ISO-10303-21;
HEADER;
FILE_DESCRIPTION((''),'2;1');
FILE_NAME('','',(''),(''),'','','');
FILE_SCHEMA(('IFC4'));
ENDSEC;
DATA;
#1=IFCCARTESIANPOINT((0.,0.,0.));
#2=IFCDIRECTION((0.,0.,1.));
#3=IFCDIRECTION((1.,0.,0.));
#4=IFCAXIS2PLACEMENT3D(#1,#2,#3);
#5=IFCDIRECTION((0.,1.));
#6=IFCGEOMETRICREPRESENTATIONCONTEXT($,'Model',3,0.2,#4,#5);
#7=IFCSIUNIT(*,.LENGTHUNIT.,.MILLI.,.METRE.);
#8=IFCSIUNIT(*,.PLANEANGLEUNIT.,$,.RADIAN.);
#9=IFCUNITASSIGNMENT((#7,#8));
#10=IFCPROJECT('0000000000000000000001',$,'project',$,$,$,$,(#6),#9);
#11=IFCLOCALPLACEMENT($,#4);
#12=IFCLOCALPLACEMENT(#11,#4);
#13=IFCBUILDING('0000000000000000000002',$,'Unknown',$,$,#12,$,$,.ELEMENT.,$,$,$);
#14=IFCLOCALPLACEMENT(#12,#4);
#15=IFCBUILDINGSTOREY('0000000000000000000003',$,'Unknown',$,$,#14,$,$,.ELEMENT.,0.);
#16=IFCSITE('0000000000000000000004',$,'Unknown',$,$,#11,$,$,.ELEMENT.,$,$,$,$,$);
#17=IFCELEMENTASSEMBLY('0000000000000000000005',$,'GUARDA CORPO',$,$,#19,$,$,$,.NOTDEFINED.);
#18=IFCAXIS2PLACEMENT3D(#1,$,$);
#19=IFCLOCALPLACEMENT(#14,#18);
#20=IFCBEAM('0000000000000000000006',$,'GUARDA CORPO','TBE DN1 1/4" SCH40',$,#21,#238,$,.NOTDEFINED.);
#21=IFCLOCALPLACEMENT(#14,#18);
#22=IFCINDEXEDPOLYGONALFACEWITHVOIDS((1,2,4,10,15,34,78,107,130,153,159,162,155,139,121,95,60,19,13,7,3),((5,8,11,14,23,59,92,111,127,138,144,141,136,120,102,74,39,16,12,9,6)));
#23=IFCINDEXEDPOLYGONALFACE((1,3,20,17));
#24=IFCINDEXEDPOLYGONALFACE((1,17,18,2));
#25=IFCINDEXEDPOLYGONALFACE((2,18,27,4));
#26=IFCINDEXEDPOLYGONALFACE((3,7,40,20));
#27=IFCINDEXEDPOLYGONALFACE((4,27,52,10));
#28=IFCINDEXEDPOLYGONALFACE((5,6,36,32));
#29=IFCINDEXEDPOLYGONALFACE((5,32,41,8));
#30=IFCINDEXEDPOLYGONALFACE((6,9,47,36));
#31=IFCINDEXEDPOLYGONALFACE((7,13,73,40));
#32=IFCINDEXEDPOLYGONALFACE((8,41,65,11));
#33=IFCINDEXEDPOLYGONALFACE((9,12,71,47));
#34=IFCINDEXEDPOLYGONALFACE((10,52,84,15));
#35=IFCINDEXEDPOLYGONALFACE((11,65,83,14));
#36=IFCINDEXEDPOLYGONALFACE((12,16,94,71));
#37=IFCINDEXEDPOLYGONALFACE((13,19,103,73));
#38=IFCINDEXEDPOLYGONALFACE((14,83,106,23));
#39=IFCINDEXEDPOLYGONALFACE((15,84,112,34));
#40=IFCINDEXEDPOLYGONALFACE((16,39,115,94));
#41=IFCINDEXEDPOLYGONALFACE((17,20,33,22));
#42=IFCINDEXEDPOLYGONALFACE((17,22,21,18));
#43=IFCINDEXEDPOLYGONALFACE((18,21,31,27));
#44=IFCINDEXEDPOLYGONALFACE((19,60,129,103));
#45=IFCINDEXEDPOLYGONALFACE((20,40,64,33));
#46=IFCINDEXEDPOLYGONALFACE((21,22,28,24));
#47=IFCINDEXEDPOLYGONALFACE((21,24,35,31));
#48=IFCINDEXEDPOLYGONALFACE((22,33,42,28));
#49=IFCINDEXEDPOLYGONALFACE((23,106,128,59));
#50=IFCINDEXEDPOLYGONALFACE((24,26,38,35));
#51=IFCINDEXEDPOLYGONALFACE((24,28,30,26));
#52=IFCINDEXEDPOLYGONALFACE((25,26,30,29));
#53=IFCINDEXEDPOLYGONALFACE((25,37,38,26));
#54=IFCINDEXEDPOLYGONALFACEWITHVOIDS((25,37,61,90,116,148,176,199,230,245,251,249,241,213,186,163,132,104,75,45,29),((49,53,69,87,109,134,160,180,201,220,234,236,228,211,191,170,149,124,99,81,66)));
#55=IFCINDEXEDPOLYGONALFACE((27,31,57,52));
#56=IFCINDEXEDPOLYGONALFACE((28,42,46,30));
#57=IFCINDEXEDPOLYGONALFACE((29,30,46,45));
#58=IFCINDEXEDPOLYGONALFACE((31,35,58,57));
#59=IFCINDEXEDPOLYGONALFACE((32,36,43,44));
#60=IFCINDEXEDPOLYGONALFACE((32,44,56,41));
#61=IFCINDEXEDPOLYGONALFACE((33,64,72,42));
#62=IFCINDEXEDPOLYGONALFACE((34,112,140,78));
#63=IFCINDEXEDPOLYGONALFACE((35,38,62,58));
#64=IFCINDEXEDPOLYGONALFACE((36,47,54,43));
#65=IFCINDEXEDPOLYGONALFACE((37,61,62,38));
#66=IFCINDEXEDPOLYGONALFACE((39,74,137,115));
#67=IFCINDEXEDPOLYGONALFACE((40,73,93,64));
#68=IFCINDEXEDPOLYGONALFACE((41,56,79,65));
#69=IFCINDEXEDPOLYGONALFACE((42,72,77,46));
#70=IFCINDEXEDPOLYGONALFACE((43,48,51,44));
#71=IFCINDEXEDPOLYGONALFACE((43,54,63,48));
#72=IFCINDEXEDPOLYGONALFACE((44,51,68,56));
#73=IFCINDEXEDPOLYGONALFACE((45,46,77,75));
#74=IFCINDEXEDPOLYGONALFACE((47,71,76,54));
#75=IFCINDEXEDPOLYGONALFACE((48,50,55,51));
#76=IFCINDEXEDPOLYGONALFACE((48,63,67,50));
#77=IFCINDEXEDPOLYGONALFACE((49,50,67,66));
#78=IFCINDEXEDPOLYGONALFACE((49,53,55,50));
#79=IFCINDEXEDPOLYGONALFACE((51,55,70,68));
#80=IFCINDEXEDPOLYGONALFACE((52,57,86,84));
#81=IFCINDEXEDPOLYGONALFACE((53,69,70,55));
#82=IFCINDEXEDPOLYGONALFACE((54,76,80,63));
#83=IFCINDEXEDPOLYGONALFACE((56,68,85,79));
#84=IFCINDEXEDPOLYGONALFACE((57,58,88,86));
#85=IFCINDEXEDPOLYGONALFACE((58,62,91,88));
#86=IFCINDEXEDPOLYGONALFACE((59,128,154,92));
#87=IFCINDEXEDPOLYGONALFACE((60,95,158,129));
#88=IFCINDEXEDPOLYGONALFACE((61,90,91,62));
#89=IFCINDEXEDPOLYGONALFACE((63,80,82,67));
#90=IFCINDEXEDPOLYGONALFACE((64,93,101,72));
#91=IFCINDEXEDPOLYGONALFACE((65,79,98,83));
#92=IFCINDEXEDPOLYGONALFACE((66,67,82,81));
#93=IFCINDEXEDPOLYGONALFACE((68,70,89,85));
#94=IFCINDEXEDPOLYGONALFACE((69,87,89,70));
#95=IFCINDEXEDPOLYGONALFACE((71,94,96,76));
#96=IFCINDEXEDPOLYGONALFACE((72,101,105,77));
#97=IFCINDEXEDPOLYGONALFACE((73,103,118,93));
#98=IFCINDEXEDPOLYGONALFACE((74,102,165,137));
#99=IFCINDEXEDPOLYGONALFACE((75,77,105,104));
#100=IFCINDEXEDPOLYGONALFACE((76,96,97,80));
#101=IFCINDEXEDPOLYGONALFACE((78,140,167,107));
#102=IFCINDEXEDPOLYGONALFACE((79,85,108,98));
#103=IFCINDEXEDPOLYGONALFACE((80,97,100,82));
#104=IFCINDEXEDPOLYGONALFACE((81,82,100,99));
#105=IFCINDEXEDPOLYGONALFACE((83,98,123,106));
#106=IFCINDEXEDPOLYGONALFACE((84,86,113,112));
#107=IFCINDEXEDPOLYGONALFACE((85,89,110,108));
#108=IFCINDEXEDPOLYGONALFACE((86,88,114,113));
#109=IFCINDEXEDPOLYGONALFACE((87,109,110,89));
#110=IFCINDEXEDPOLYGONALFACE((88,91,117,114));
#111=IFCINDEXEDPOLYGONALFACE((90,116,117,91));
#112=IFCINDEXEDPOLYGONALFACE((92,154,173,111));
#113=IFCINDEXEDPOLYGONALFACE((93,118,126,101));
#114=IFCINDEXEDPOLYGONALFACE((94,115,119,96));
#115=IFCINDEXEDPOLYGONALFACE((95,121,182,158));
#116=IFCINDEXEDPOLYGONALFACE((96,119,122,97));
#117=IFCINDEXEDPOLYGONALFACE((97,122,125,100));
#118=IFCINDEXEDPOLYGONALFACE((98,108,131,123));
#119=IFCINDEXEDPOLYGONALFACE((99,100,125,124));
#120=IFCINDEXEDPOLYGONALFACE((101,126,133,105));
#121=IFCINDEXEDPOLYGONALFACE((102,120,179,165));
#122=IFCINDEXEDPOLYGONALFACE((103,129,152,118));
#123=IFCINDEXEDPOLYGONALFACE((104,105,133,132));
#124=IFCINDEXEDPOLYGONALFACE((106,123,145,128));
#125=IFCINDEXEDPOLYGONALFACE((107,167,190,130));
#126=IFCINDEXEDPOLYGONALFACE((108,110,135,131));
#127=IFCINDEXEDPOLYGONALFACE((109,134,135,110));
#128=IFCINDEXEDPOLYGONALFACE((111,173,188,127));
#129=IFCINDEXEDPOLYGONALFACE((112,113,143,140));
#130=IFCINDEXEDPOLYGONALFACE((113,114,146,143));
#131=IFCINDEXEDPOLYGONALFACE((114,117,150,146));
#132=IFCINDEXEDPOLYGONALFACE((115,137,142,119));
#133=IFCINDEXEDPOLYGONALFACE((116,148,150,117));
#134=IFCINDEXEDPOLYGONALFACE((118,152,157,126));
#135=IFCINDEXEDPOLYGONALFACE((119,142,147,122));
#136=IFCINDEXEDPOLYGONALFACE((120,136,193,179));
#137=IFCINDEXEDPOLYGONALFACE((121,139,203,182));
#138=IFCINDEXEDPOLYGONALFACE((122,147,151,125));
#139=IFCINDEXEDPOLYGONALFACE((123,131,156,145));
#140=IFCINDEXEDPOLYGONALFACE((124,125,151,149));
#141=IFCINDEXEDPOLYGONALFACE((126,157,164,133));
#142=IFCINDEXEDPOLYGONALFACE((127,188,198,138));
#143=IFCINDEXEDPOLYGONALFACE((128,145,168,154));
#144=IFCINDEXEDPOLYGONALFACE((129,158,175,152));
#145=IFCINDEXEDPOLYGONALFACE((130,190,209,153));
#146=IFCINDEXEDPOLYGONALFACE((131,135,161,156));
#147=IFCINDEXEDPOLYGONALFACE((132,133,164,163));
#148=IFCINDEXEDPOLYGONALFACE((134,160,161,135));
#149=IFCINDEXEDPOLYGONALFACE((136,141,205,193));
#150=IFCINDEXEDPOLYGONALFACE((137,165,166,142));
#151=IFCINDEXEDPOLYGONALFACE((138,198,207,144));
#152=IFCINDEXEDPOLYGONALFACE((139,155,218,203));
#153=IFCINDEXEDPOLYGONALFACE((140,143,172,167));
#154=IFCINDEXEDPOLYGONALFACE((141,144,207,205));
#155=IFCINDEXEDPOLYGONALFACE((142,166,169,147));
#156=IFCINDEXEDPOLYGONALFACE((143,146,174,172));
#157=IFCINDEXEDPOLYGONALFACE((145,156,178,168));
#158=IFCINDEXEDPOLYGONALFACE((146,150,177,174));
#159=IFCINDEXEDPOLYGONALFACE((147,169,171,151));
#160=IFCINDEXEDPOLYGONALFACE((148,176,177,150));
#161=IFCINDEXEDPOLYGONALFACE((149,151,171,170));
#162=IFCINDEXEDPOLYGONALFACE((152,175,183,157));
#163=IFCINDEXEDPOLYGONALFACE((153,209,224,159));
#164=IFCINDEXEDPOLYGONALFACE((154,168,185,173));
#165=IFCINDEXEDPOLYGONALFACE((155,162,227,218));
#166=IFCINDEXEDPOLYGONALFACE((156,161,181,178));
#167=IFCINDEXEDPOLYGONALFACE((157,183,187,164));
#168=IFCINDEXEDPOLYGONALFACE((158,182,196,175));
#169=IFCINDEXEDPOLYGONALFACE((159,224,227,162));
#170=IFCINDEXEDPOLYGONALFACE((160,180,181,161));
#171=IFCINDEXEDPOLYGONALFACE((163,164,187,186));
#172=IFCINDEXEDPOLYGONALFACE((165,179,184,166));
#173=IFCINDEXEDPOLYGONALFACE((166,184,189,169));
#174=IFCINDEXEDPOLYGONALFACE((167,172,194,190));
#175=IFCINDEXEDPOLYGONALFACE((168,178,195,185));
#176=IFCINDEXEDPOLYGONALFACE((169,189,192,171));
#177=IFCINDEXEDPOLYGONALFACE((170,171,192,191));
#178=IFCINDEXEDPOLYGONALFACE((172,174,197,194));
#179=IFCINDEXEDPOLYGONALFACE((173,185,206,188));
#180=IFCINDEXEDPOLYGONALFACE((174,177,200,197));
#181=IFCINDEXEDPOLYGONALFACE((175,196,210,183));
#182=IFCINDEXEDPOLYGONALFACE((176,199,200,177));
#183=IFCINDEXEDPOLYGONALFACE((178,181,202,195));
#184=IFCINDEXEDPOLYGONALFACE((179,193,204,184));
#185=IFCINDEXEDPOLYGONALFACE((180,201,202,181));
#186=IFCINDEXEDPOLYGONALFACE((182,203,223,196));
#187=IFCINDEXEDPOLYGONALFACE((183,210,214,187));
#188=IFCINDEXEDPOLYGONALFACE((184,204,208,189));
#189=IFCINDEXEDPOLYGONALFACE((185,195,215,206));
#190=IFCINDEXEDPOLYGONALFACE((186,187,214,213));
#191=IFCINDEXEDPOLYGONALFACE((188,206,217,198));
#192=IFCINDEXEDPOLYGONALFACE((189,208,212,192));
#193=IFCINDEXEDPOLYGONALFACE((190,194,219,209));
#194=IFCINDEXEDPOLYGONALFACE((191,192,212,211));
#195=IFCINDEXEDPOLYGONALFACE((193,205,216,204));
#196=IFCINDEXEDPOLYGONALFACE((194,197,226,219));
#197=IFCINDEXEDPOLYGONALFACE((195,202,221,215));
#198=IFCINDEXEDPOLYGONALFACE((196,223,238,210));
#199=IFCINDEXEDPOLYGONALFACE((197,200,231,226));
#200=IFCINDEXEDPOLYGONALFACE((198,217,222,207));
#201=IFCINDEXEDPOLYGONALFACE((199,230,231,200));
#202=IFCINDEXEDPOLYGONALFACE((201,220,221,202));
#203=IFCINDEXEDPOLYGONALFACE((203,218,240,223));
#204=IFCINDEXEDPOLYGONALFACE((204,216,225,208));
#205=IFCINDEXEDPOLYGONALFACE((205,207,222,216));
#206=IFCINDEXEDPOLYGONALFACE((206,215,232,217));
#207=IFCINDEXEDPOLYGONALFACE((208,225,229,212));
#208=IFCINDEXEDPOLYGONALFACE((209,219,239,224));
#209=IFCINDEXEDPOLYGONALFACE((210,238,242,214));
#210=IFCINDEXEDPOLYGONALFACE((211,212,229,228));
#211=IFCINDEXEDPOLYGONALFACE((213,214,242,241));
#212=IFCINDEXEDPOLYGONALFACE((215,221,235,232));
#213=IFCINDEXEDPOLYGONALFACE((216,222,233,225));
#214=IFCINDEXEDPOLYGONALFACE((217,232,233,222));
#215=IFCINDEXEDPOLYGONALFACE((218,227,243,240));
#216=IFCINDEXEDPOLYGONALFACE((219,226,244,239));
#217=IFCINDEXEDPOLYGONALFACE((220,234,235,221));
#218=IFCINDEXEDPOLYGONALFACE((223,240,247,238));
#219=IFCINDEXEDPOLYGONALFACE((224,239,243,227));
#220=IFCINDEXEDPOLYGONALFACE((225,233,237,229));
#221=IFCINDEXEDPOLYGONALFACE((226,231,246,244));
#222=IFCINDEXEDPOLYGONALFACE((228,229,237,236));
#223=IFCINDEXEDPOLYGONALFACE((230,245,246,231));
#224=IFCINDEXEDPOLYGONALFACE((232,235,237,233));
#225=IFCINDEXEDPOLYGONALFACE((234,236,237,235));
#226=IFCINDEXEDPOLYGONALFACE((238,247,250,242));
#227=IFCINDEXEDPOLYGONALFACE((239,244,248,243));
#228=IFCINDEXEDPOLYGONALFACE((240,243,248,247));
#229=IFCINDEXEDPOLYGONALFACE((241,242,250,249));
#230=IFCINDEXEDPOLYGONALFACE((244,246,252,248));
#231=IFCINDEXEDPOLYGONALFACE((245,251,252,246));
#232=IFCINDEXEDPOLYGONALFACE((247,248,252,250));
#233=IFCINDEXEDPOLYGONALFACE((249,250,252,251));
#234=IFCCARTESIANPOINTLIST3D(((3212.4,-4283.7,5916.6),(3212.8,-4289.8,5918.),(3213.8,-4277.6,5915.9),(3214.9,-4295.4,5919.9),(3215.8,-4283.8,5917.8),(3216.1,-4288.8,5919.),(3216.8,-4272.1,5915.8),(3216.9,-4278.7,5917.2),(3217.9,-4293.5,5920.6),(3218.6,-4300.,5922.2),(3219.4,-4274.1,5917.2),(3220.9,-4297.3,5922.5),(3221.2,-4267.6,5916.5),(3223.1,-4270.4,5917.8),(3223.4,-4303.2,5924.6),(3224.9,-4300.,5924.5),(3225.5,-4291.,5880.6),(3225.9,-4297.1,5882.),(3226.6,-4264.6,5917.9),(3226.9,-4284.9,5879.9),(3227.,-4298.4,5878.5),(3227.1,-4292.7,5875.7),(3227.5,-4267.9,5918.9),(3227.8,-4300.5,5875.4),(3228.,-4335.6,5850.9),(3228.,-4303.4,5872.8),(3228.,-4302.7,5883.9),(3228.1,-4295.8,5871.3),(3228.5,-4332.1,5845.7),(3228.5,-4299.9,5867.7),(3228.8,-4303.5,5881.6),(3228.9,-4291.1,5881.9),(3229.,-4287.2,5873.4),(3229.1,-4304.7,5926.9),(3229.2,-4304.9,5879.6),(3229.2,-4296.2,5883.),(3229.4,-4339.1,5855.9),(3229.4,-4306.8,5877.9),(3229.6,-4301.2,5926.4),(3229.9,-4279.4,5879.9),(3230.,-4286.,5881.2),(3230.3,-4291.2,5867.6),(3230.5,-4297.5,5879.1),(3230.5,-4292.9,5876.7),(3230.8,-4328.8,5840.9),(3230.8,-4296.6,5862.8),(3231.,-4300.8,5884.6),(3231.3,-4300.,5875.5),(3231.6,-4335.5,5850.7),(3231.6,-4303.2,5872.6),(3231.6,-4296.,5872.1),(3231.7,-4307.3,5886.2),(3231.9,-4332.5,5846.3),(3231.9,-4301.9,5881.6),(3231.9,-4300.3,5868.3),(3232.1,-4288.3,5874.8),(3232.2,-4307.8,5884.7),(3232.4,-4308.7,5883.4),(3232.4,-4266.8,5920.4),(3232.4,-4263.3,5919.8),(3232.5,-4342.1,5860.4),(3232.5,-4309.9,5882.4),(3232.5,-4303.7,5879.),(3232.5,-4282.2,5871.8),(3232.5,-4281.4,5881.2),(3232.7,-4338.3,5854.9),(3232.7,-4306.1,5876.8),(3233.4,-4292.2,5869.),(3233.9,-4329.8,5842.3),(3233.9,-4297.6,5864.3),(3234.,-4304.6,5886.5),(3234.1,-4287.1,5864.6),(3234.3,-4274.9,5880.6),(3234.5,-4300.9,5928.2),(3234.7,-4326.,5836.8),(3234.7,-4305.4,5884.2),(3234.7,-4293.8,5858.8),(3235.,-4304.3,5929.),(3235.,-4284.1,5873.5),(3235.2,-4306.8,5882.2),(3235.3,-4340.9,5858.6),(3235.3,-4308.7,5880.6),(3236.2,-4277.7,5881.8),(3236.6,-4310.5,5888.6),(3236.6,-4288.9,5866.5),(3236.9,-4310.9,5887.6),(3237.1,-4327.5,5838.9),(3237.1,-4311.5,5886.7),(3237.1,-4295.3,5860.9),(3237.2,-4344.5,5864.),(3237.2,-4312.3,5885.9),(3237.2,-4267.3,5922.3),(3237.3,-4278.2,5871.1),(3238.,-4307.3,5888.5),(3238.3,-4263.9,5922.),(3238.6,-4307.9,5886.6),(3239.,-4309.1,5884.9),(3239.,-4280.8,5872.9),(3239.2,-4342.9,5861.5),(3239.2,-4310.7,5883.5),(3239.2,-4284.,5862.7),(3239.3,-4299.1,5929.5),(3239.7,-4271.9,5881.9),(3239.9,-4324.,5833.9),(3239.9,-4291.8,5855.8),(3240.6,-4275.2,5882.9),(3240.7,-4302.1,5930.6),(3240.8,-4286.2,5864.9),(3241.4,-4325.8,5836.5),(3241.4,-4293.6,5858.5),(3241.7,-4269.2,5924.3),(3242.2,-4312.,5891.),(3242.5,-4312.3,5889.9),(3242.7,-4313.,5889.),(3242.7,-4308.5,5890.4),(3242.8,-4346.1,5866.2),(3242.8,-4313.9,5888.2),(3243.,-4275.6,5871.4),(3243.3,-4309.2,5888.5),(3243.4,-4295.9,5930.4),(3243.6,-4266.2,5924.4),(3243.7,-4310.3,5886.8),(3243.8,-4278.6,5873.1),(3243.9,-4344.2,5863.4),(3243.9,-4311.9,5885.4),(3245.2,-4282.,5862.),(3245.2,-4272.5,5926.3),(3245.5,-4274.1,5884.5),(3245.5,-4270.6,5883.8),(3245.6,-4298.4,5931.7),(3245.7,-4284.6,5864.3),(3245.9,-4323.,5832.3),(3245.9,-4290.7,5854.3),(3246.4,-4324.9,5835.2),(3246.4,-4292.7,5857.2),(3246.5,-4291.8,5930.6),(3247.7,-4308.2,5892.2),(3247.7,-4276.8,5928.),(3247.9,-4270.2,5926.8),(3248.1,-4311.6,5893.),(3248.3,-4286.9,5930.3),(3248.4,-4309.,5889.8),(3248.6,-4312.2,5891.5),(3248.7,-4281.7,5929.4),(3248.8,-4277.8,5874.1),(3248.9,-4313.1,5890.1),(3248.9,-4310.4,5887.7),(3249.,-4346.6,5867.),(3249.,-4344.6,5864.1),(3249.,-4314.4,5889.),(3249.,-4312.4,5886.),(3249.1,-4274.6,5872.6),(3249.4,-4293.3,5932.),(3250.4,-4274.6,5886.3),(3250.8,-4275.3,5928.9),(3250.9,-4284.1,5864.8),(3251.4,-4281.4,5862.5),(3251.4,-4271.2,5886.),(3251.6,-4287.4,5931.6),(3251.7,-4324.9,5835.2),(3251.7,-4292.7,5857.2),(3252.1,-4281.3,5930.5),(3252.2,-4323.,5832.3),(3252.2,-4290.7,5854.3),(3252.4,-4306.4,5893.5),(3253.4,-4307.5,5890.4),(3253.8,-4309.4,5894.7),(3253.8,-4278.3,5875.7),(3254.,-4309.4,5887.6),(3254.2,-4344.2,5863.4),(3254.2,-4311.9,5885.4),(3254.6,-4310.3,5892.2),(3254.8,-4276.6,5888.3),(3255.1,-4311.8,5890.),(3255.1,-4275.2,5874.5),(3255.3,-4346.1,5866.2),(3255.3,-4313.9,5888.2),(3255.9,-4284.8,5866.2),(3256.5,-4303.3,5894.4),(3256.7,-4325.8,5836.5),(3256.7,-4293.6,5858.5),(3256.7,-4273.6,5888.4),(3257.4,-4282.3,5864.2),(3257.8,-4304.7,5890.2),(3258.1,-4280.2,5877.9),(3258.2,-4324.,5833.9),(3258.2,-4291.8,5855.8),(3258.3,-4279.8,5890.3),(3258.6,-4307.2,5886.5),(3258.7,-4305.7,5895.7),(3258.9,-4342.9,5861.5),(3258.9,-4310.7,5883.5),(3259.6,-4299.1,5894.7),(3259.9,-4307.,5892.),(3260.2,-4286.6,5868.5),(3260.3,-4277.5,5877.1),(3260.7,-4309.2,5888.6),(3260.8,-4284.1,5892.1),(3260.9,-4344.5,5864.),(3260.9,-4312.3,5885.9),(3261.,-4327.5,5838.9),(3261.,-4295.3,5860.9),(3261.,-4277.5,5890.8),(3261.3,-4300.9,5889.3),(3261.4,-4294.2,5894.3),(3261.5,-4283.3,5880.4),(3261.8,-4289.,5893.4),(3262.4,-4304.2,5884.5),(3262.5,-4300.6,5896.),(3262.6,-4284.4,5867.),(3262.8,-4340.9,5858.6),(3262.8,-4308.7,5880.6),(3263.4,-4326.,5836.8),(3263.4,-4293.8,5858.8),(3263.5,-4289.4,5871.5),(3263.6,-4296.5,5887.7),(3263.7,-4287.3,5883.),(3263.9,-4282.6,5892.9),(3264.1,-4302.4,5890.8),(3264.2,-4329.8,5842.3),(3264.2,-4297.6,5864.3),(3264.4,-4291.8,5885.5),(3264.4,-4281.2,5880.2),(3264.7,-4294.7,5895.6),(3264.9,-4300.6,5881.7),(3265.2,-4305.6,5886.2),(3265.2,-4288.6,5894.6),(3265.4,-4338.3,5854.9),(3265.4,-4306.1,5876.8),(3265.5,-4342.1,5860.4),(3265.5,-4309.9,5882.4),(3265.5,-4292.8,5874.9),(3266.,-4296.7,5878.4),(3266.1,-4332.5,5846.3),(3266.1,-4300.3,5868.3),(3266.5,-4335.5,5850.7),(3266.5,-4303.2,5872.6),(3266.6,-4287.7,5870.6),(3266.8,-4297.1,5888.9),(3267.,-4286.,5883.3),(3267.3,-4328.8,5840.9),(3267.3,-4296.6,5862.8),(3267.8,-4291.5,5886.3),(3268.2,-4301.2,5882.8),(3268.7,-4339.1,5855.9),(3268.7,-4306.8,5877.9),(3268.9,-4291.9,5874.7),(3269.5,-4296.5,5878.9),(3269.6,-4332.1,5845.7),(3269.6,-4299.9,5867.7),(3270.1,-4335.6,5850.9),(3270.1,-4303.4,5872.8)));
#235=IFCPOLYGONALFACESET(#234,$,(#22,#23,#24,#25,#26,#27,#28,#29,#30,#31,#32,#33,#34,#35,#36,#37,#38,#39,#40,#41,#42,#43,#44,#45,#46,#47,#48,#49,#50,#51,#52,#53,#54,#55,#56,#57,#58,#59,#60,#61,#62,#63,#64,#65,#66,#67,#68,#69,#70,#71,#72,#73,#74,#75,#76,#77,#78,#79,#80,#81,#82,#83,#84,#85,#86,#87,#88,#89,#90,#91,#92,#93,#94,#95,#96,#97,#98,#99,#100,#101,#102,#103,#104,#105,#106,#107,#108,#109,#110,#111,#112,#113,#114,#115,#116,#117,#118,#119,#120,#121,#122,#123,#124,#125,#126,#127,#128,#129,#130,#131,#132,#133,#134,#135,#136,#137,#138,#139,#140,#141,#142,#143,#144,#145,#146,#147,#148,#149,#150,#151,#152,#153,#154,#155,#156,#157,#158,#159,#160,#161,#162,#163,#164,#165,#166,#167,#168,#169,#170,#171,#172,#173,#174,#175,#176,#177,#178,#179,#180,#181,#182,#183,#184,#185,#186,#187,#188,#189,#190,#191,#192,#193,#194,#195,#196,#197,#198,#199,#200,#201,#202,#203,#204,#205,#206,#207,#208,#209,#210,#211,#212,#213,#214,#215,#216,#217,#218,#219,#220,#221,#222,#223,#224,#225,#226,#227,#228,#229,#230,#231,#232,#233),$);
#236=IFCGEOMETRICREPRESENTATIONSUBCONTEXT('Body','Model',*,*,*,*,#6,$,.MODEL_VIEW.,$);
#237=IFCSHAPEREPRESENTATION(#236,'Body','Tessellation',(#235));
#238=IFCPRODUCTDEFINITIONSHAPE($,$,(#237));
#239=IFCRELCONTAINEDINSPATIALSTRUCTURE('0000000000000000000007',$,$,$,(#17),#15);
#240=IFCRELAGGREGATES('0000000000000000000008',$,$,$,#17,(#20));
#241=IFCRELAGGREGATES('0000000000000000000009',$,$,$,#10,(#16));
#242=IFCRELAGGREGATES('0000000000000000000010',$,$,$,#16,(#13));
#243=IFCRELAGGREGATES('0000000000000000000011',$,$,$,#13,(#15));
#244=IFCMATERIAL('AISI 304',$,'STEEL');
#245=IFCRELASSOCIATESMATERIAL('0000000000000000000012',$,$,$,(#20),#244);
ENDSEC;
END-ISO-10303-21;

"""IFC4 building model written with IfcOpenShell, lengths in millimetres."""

from ifc_helpers import new_model, entity, si_unit, direction, frame, origin_with_axes, place, context, subcontext, project, spatial, material, element, aggregate, save


model = new_model("IFC4")

# Units and contexts
model_context = context("Model", 3, precision=0.2, world=origin_with_axes(), true_north=direction((0.0, 1.0)))
body_context = subcontext(model_context, "Body", "Model", "MODEL_VIEW")
ifc_project = project(units=[si_unit("LENGTHUNIT", "METRE", prefix="MILLI"), si_unit("PLANEANGLEUNIT", "RADIAN")], contexts=[model_context])

# Site, building, storey
site_placement = place(None, origin_with_axes())
site = spatial("IfcSite", under=ifc_project, at=site_placement, Name="Unknown", CompositionType="ELEMENT")
building_placement = place(site_placement, origin_with_axes())
building = spatial("IfcBuilding", under=site, at=building_placement, Name="Unknown", CompositionType="ELEMENT")
storey_placement = place(building_placement, origin_with_axes())
storey = spatial("IfcBuildingStorey", under=building, at=storey_placement, Name="Unknown", CompositionType="ELEMENT", Elevation=0.0)

# Element assembly, beam
assembly_1_placement = place(storey_placement, frame((2908.2, -5645.6, 3955.0), z_axis=(0.000512, -1.0, -0.000003), x_axis=(0.000003, -0.000003, 1.0)))
assembly_1 = element("IfcElementAssembly", 1, at=assembly_1_placement, inside=storey, Name="GUARDA CORPO", PredefinedType="NOTDEFINED")
ifc_material_1 = material(Name="AISI 304", Category="STEEL")
beam_1_placement = place(assembly_1_placement, frame((1894.6, -341.6, -1310.7), z_axis=(0.826215, 0.000295, 0.563355), x_axis=(0.563355, -0.000419, -0.826215)))
beam_1 = element("IfcBeam", 2, at=beam_1_placement, material=ifc_material_1, Name="GUARDA CORPO", Description="TBE DN1 1/4\" SCH40", PredefinedType="NOTDEFINED", context=body_context, shape_type="SolidModel", body=[
    entity("IfcSweptDiskSolid", entity("IfcIndexedPolyCurve", entity("IfcCartesianPointList3D", [[0.0, 0.0, 0.0], [39.0, 0.0, 0.0], [49.1, 1.0, 1.9], [57.4, 3.7, 7.2], [83.7, 16.8, 32.9]]), [entity("IfcLineIndex", [1, 2]), entity("IfcArcIndex", [2, 3, 4]), entity("IfcLineIndex", [4, 5])]), 21.1, 17.5),
])

aggregate(assembly_1, [beam_1])

save(model, "model.ifc")
